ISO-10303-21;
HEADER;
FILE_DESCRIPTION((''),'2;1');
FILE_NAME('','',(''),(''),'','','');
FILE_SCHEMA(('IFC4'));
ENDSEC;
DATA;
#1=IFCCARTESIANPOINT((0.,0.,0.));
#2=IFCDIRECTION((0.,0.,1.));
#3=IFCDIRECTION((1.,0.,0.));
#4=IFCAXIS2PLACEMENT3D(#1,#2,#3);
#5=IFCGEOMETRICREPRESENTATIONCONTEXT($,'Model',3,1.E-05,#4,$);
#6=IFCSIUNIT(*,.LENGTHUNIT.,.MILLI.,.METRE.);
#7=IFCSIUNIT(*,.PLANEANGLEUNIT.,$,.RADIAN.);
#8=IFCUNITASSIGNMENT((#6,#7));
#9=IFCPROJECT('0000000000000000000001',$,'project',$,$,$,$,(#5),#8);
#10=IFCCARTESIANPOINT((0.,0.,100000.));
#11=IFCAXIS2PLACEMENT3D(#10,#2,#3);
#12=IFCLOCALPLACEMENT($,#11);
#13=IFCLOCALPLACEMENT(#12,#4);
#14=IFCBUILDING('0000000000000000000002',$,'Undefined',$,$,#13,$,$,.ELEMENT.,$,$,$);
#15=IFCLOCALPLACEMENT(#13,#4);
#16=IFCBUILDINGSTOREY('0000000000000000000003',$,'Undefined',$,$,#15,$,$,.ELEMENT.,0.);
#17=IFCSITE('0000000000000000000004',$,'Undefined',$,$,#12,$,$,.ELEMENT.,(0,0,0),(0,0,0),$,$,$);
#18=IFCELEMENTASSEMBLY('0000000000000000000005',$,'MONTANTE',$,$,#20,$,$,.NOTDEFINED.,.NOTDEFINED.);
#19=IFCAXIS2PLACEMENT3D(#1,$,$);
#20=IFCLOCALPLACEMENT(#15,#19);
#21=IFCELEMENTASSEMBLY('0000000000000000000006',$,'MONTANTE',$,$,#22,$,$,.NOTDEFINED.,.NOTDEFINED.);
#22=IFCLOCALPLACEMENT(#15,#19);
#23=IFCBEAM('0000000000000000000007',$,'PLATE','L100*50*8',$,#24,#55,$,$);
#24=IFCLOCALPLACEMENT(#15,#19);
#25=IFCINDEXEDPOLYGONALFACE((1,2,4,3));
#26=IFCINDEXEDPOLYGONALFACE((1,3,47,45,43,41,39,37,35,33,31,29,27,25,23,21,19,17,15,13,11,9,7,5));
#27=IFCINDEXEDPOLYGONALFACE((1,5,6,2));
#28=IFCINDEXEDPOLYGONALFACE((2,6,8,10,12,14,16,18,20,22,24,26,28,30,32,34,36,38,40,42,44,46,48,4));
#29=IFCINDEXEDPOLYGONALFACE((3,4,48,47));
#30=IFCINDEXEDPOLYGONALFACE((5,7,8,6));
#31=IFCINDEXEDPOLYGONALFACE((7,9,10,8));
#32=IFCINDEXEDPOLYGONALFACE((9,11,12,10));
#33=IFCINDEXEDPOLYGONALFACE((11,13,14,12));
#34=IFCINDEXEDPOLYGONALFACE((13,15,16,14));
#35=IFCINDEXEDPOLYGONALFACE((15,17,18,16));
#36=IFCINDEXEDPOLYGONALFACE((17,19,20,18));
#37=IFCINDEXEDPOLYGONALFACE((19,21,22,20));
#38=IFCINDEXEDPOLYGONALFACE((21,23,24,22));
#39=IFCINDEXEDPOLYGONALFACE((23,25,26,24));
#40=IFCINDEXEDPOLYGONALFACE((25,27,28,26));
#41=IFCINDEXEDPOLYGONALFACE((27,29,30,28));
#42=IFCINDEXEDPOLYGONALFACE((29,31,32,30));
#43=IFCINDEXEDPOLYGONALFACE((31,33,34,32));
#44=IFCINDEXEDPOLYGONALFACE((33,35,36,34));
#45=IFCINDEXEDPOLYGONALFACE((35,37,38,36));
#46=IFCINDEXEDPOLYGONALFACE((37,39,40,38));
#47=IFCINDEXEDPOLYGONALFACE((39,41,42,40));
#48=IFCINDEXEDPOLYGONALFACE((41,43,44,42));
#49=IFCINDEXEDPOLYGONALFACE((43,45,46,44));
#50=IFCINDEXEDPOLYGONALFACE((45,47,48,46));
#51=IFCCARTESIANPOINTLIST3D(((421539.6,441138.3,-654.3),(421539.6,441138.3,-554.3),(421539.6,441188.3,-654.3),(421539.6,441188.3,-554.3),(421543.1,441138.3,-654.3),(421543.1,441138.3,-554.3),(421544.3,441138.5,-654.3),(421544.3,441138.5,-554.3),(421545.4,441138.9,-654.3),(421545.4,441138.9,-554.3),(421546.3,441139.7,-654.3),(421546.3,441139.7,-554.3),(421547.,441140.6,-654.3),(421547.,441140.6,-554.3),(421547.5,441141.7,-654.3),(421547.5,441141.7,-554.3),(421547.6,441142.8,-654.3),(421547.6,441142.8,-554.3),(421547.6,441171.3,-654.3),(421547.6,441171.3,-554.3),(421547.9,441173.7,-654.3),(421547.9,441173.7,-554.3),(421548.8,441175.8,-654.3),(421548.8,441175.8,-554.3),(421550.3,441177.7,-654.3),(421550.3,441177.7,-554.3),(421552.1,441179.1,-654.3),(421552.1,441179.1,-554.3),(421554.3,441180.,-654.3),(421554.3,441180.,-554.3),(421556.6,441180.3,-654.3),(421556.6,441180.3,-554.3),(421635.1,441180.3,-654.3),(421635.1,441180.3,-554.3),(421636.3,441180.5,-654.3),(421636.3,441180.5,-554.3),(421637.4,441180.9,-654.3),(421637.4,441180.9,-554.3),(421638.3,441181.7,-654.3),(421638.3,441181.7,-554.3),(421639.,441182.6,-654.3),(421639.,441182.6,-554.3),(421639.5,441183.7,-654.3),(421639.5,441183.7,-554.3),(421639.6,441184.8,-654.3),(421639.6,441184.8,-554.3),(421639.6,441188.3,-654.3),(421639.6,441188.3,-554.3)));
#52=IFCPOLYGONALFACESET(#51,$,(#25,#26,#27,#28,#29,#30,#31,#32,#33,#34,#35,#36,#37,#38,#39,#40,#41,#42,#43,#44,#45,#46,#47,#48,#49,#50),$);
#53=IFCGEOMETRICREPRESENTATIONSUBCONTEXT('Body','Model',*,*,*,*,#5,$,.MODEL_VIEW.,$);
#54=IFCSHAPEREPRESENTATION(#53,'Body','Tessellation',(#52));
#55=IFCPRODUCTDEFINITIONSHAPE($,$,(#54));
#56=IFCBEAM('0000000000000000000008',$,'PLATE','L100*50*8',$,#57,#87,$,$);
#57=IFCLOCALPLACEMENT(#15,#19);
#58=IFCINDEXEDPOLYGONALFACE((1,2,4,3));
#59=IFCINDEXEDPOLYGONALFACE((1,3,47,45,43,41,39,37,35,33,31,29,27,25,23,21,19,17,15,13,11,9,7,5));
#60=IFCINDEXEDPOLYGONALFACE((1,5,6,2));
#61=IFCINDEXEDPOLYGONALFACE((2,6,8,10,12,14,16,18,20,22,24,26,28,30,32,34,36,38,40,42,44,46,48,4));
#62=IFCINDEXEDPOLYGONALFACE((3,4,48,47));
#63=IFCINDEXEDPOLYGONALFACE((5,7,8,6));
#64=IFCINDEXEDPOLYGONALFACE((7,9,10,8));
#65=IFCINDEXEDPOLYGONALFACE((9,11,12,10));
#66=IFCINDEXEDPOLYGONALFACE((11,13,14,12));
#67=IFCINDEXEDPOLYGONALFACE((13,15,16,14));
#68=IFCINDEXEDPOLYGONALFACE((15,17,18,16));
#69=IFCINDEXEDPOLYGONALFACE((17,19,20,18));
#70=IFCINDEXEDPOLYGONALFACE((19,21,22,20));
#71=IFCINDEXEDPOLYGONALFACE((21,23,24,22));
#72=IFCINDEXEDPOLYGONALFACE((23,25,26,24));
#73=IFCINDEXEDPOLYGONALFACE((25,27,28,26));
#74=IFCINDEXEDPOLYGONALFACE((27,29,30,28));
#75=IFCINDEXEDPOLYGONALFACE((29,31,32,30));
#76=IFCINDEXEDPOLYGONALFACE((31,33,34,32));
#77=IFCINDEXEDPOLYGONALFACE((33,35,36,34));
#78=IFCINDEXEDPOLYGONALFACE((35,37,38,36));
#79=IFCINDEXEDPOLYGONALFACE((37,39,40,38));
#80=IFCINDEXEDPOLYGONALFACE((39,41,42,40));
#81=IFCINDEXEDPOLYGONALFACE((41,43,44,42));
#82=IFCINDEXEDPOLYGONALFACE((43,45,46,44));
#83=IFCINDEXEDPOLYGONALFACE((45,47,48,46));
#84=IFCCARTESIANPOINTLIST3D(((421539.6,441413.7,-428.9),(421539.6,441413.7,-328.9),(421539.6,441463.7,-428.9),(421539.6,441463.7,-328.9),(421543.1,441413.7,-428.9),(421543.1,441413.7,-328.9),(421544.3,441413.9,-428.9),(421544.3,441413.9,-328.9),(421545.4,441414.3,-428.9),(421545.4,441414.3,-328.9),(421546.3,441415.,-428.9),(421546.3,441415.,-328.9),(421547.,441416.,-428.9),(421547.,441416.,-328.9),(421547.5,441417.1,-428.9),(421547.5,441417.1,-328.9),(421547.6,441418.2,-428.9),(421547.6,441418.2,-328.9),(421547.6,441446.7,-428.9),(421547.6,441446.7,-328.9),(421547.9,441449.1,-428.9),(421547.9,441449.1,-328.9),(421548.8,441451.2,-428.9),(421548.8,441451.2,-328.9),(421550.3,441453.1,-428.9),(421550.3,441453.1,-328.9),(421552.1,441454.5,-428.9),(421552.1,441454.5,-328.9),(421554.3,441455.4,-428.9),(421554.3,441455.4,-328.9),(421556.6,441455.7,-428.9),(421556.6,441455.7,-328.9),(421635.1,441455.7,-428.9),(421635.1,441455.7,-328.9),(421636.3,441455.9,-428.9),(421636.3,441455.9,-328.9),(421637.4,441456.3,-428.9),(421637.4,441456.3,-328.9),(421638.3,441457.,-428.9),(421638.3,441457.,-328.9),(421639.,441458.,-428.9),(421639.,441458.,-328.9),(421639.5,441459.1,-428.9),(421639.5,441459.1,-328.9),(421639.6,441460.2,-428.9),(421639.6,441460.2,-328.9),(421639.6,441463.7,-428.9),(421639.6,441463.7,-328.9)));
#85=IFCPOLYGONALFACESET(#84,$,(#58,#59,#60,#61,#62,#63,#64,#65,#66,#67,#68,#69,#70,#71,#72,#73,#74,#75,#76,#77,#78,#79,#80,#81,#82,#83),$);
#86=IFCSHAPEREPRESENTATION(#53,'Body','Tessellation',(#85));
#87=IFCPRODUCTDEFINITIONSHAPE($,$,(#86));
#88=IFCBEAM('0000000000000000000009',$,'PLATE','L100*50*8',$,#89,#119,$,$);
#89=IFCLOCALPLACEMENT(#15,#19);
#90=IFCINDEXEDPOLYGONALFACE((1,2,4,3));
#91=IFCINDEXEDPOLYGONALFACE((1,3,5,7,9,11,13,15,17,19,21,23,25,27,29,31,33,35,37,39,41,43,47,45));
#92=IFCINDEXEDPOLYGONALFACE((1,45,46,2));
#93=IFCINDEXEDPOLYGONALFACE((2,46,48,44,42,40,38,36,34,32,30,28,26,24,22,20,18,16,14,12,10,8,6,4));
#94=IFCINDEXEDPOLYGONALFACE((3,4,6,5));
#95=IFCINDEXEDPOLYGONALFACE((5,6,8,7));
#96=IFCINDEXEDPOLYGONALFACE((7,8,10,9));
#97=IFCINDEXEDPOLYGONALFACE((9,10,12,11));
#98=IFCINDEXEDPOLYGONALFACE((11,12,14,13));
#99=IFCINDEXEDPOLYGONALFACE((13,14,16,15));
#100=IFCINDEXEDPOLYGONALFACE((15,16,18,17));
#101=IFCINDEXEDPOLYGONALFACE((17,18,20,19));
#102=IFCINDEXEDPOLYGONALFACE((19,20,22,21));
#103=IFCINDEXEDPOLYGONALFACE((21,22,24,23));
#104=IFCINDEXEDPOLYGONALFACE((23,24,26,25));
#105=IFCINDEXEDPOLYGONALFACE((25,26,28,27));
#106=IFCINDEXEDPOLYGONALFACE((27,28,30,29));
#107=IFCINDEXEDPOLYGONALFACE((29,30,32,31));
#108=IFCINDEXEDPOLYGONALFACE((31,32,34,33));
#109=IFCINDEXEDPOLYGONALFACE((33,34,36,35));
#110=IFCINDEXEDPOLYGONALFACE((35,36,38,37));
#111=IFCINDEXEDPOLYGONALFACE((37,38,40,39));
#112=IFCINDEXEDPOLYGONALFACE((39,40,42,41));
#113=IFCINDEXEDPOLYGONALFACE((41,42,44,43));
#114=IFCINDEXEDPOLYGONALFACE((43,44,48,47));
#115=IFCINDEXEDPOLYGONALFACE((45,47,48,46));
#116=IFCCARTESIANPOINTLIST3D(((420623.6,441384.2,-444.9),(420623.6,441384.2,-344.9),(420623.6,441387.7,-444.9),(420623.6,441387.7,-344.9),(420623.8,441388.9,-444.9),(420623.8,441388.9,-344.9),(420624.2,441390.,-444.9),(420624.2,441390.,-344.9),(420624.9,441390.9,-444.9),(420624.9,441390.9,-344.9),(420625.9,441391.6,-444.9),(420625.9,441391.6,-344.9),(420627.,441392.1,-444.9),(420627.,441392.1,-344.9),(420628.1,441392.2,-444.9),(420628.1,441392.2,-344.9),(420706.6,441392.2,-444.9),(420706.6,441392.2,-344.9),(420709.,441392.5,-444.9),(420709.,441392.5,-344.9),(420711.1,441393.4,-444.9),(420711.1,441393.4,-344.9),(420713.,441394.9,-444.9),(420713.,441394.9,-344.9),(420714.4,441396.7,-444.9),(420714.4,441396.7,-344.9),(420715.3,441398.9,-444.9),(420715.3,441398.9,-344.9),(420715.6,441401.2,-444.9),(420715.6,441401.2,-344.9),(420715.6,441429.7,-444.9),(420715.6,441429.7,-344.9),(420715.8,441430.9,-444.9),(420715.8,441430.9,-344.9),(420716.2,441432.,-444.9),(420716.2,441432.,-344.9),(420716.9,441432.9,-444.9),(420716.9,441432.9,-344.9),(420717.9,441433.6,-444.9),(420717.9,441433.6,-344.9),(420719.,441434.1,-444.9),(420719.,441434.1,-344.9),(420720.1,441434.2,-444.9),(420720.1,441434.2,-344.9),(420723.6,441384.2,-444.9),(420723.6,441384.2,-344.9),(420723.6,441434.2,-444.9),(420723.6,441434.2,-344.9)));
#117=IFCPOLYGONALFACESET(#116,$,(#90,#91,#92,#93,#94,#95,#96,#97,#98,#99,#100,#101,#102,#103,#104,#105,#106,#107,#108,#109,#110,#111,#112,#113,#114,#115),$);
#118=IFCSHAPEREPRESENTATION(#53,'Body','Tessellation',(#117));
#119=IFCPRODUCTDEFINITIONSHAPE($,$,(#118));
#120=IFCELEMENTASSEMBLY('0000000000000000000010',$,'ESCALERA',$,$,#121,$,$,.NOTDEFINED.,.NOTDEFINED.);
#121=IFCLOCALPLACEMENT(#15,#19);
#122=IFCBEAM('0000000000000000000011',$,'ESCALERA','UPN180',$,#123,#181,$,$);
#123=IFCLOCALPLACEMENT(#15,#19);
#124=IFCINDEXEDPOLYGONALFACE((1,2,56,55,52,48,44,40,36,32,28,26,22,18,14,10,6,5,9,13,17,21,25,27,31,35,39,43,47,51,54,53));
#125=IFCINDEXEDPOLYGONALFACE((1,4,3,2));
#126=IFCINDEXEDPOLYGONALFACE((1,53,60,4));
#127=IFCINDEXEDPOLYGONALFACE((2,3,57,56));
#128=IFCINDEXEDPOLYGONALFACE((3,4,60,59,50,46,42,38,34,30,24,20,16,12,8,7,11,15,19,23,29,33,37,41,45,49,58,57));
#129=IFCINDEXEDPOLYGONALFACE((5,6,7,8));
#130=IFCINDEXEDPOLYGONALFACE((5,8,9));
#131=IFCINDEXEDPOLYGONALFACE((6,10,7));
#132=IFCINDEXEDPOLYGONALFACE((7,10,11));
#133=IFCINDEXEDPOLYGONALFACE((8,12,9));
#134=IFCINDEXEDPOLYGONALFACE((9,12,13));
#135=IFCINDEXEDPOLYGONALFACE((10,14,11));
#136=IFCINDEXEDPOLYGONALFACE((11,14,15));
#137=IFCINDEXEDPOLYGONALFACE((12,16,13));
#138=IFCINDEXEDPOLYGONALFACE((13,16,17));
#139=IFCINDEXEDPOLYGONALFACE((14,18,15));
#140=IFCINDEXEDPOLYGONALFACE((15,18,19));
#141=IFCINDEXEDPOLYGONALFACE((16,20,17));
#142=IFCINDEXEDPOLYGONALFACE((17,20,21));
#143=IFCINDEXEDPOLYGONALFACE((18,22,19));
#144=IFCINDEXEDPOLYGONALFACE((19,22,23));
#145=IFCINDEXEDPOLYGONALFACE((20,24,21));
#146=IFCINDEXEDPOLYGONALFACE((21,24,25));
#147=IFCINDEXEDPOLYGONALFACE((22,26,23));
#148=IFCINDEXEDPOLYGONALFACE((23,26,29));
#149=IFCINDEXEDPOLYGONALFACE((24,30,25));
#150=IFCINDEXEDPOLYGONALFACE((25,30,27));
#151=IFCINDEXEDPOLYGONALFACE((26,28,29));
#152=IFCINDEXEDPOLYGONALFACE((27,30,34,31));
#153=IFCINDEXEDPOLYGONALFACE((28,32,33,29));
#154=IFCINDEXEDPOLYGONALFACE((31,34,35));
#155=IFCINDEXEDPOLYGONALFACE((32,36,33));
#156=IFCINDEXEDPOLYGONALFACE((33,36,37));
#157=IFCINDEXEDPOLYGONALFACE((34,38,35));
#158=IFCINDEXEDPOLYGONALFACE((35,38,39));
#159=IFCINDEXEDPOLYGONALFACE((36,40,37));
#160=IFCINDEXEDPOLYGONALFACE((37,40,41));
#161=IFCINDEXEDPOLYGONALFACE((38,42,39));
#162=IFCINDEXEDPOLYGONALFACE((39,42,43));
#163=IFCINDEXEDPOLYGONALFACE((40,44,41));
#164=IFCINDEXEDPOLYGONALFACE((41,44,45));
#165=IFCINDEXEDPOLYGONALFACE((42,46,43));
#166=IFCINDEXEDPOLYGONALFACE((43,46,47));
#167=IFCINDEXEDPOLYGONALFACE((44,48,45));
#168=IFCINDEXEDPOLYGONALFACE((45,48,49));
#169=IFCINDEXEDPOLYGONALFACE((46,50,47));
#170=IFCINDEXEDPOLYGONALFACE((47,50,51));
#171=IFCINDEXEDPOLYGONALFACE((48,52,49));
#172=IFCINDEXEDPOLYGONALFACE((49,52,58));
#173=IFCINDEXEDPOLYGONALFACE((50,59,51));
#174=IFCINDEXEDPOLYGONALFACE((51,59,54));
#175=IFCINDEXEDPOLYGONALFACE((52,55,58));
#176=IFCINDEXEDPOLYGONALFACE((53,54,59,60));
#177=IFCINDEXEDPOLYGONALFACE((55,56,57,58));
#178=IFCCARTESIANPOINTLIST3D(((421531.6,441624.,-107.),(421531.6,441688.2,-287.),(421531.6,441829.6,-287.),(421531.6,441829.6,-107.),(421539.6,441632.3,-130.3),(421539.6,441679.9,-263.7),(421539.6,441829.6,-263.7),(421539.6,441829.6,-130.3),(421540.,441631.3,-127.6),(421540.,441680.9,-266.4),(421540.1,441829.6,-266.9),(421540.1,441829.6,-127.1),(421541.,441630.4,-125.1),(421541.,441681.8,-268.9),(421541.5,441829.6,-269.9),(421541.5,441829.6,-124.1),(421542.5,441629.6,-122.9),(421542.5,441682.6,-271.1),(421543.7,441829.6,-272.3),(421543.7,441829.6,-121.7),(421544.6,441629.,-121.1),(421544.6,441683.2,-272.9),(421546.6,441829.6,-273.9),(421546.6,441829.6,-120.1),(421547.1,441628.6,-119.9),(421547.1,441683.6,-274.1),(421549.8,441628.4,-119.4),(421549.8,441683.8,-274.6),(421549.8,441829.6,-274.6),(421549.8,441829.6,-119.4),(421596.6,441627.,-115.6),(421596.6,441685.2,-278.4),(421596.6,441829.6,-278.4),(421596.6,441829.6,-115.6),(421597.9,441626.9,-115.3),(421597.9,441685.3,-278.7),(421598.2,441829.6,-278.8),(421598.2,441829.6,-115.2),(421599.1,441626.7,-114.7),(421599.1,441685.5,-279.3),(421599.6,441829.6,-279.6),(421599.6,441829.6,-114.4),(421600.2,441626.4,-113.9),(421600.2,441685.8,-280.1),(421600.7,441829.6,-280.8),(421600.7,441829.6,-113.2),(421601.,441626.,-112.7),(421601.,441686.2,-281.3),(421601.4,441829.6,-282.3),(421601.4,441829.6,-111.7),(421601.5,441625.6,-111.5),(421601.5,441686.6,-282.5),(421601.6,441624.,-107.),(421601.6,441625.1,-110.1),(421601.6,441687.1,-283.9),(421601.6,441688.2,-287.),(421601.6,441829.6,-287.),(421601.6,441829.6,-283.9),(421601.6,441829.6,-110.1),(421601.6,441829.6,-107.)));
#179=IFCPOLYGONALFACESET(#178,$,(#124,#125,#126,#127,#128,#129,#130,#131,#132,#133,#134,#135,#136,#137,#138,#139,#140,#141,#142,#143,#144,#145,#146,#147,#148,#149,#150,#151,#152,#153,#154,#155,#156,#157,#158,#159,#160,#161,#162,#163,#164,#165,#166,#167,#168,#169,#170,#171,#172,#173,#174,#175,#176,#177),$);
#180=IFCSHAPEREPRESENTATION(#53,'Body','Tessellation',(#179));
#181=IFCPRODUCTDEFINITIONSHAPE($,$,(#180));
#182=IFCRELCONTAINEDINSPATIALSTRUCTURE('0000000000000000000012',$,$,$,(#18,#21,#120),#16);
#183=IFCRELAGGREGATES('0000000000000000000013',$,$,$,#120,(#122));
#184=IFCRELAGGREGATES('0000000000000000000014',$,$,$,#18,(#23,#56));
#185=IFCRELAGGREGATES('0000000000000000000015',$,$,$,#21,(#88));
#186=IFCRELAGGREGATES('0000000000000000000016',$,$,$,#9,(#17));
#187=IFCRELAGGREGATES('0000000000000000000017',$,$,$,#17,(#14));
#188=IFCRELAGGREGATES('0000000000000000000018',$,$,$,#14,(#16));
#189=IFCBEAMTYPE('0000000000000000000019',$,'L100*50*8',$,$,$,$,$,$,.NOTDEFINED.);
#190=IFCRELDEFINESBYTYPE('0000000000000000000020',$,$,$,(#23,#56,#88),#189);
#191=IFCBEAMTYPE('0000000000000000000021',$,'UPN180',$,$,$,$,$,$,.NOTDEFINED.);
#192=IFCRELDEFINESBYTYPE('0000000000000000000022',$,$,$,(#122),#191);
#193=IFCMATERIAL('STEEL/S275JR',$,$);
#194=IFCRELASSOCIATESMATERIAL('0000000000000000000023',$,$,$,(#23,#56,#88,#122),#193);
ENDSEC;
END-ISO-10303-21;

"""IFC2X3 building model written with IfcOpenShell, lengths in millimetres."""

from ifc_helpers import new_model, si_unit, frame, origin_with_axes, origin_2d_with_axis, place, context, subcontext, project, spatial, l_section, u_section, extrude, clip, halfspace, material, type_object, element, aggregate, save


model = new_model("IFC2X3")

# Units and contexts
model_context = context("Model", 3, precision=1e-05, world=origin_with_axes())
body_context = subcontext(model_context, "Body", "Model", "MODEL_VIEW")
ifc_project = project(units=[si_unit("LENGTHUNIT", "METRE", prefix="MILLI"), si_unit("PLANEANGLEUNIT", "RADIAN")], contexts=[model_context])

# Site, building, storey
site_placement = place(None, frame((0.0, 0.0, 100000.0), z_axis=(0.0, 0.0, 1.0), x_axis=(1.0, 0.0, 0.0)))
site = spatial("IfcSite", under=ifc_project, at=site_placement, Name="Undefined", CompositionType="ELEMENT", RefLatitude=(0, 0, 0), RefLongitude=(0, 0, 0))
building_placement = place(site_placement, origin_with_axes())
building = spatial("IfcBuilding", under=site, at=building_placement, Name="Undefined", CompositionType="ELEMENT")
storey_placement = place(building_placement, origin_with_axes())
storey = spatial("IfcBuildingStorey", under=building, at=storey_placement, Name="Undefined", CompositionType="ELEMENT", Elevation=0.0)

# Element assemblies
assembly_1_placement = place(storey_placement, origin_with_axes())
assembly_1 = element("IfcElementAssembly", 1, at=assembly_1_placement, inside=storey, Name="MONTANTE", AssemblyPlace="NOTDEFINED", PredefinedType="NOTDEFINED")
assembly_2_placement = place(storey_placement, origin_with_axes())
assembly_2 = element("IfcElementAssembly", 2, at=assembly_2_placement, inside=storey, Name="MONTANTE", AssemblyPlace="NOTDEFINED", PredefinedType="NOTDEFINED")

# Beams
ifc_material_1 = material(Name="STEEL/S275JR")
beam_type_1 = type_object("IfcBeamType", Name="L100*50*8", PredefinedType="NOTDEFINED")
beam_1_placement = place(assembly_1_placement, frame((421589.6, 441163.3, -554.3), z_axis=(1.0, -0.000001, 0.0), x_axis=(0.0, 0.0, -1.0)))
beam_1 = element("IfcBeam", 3, at=beam_1_placement, type_object=beam_type_1, material=ifc_material_1, Name="PLATE", Description="L100*50*8", context=body_context, shape_type="SweptSolid", body=[
    extrude(l_section(Depth=100.0, Width=50.0, Thickness=8.0, FilletRadius=9.0, EdgeRadius=4.5, at=origin_2d_with_axis()), frame((100.0, 0.0, 0.0), z_axis=(-1.0, 0.0, 0.0), x_axis=(0.0, -1.0, 0.0)), (0.0, 0.0, 1.0), 100.0),
])
beam_2_placement = place(assembly_1_placement, frame((421589.6, 441438.7, -328.9), z_axis=(1.0, -0.000001, 0.0), x_axis=(0.0, 0.0, -1.0)))
beam_2 = element("IfcBeam", 4, at=beam_2_placement, type_object=beam_type_1, material=ifc_material_1, Name="PLATE", Description="L100*50*8", context=body_context, shape_type="SweptSolid", body=[
    extrude(l_section(Depth=100.0, Width=50.0, Thickness=8.0, FilletRadius=9.0, EdgeRadius=4.5, at=origin_2d_with_axis()), frame((100.0, 0.0, 0.0), z_axis=(-1.0, 0.0, 0.0), x_axis=(0.0, -1.0, 0.0)), (0.0, 0.0, 1.0), 100.0),
])
beam_3_placement = place(assembly_2_placement, frame((420673.6, 441409.2, -344.9), z_axis=(-1.0, 0.000001, 0.0), x_axis=(0.0, 0.0, -1.0)))
beam_3 = element("IfcBeam", 5, at=beam_3_placement, type_object=beam_type_1, material=ifc_material_1, Name="PLATE", Description="L100*50*8", context=body_context, shape_type="SweptSolid", body=[
    extrude(l_section(Depth=100.0, Width=50.0, Thickness=8.0, FilletRadius=9.0, EdgeRadius=4.5, at=origin_2d_with_axis()), frame((100.0, 0.0, 0.0), z_axis=(-1.0, 0.0, 0.0), x_axis=(0.0, -1.0, 0.0)), (0.0, 0.0, 1.0), 100.0),
])

# Element assembly, beam
assembly_3_placement = place(storey_placement, origin_with_axes())
assembly_3 = element("IfcElementAssembly", 6, at=assembly_3_placement, inside=storey, Name="ESCALERA", AssemblyPlace="NOTDEFINED", PredefinedType="NOTDEFINED")
beam_type_2 = type_object("IfcBeamType", Name="UPN180", PredefinedType="NOTDEFINED")
beam_4_placement = place(assembly_3_placement, frame((421566.6, 441624.0, -197.0), z_axis=(0.0, 0.0, 1.0), x_axis=(0.000001, 1.0, 0.0)))
beam_4 = element("IfcBeam", 7, at=beam_4_placement, type_object=beam_type_2, material=ifc_material_1, Name="ESCALERA", Description="UPN180", context=body_context, shape_type="Clipping", body=[
    clip(extrude(u_section(Depth=180.0, FlangeWidth=70.0, WebThickness=8.0, FlangeThickness=11.0, FilletRadius=11.0, EdgeRadius=5.5, FlangeSlope=0.07983, at=origin_2d_with_axis()), frame((205.6, 0.0, 0.0), z_axis=(-1.0, 0.0, 0.0), x_axis=(0.0, -1.0, 0.0)), (0.0, 0.0, 1.0), 206.0), halfspace(frame((0.0, -35.0, 90.0), z_axis=(-0.941795, 0.0, -0.336186), x_axis=(0.0, -1.0, 0.0)), False)),
])
aggregate(assembly_3, [beam_4])

aggregate(assembly_1, [beam_1, beam_2])
aggregate(assembly_2, [beam_3])

save(model, "model.ifc")
